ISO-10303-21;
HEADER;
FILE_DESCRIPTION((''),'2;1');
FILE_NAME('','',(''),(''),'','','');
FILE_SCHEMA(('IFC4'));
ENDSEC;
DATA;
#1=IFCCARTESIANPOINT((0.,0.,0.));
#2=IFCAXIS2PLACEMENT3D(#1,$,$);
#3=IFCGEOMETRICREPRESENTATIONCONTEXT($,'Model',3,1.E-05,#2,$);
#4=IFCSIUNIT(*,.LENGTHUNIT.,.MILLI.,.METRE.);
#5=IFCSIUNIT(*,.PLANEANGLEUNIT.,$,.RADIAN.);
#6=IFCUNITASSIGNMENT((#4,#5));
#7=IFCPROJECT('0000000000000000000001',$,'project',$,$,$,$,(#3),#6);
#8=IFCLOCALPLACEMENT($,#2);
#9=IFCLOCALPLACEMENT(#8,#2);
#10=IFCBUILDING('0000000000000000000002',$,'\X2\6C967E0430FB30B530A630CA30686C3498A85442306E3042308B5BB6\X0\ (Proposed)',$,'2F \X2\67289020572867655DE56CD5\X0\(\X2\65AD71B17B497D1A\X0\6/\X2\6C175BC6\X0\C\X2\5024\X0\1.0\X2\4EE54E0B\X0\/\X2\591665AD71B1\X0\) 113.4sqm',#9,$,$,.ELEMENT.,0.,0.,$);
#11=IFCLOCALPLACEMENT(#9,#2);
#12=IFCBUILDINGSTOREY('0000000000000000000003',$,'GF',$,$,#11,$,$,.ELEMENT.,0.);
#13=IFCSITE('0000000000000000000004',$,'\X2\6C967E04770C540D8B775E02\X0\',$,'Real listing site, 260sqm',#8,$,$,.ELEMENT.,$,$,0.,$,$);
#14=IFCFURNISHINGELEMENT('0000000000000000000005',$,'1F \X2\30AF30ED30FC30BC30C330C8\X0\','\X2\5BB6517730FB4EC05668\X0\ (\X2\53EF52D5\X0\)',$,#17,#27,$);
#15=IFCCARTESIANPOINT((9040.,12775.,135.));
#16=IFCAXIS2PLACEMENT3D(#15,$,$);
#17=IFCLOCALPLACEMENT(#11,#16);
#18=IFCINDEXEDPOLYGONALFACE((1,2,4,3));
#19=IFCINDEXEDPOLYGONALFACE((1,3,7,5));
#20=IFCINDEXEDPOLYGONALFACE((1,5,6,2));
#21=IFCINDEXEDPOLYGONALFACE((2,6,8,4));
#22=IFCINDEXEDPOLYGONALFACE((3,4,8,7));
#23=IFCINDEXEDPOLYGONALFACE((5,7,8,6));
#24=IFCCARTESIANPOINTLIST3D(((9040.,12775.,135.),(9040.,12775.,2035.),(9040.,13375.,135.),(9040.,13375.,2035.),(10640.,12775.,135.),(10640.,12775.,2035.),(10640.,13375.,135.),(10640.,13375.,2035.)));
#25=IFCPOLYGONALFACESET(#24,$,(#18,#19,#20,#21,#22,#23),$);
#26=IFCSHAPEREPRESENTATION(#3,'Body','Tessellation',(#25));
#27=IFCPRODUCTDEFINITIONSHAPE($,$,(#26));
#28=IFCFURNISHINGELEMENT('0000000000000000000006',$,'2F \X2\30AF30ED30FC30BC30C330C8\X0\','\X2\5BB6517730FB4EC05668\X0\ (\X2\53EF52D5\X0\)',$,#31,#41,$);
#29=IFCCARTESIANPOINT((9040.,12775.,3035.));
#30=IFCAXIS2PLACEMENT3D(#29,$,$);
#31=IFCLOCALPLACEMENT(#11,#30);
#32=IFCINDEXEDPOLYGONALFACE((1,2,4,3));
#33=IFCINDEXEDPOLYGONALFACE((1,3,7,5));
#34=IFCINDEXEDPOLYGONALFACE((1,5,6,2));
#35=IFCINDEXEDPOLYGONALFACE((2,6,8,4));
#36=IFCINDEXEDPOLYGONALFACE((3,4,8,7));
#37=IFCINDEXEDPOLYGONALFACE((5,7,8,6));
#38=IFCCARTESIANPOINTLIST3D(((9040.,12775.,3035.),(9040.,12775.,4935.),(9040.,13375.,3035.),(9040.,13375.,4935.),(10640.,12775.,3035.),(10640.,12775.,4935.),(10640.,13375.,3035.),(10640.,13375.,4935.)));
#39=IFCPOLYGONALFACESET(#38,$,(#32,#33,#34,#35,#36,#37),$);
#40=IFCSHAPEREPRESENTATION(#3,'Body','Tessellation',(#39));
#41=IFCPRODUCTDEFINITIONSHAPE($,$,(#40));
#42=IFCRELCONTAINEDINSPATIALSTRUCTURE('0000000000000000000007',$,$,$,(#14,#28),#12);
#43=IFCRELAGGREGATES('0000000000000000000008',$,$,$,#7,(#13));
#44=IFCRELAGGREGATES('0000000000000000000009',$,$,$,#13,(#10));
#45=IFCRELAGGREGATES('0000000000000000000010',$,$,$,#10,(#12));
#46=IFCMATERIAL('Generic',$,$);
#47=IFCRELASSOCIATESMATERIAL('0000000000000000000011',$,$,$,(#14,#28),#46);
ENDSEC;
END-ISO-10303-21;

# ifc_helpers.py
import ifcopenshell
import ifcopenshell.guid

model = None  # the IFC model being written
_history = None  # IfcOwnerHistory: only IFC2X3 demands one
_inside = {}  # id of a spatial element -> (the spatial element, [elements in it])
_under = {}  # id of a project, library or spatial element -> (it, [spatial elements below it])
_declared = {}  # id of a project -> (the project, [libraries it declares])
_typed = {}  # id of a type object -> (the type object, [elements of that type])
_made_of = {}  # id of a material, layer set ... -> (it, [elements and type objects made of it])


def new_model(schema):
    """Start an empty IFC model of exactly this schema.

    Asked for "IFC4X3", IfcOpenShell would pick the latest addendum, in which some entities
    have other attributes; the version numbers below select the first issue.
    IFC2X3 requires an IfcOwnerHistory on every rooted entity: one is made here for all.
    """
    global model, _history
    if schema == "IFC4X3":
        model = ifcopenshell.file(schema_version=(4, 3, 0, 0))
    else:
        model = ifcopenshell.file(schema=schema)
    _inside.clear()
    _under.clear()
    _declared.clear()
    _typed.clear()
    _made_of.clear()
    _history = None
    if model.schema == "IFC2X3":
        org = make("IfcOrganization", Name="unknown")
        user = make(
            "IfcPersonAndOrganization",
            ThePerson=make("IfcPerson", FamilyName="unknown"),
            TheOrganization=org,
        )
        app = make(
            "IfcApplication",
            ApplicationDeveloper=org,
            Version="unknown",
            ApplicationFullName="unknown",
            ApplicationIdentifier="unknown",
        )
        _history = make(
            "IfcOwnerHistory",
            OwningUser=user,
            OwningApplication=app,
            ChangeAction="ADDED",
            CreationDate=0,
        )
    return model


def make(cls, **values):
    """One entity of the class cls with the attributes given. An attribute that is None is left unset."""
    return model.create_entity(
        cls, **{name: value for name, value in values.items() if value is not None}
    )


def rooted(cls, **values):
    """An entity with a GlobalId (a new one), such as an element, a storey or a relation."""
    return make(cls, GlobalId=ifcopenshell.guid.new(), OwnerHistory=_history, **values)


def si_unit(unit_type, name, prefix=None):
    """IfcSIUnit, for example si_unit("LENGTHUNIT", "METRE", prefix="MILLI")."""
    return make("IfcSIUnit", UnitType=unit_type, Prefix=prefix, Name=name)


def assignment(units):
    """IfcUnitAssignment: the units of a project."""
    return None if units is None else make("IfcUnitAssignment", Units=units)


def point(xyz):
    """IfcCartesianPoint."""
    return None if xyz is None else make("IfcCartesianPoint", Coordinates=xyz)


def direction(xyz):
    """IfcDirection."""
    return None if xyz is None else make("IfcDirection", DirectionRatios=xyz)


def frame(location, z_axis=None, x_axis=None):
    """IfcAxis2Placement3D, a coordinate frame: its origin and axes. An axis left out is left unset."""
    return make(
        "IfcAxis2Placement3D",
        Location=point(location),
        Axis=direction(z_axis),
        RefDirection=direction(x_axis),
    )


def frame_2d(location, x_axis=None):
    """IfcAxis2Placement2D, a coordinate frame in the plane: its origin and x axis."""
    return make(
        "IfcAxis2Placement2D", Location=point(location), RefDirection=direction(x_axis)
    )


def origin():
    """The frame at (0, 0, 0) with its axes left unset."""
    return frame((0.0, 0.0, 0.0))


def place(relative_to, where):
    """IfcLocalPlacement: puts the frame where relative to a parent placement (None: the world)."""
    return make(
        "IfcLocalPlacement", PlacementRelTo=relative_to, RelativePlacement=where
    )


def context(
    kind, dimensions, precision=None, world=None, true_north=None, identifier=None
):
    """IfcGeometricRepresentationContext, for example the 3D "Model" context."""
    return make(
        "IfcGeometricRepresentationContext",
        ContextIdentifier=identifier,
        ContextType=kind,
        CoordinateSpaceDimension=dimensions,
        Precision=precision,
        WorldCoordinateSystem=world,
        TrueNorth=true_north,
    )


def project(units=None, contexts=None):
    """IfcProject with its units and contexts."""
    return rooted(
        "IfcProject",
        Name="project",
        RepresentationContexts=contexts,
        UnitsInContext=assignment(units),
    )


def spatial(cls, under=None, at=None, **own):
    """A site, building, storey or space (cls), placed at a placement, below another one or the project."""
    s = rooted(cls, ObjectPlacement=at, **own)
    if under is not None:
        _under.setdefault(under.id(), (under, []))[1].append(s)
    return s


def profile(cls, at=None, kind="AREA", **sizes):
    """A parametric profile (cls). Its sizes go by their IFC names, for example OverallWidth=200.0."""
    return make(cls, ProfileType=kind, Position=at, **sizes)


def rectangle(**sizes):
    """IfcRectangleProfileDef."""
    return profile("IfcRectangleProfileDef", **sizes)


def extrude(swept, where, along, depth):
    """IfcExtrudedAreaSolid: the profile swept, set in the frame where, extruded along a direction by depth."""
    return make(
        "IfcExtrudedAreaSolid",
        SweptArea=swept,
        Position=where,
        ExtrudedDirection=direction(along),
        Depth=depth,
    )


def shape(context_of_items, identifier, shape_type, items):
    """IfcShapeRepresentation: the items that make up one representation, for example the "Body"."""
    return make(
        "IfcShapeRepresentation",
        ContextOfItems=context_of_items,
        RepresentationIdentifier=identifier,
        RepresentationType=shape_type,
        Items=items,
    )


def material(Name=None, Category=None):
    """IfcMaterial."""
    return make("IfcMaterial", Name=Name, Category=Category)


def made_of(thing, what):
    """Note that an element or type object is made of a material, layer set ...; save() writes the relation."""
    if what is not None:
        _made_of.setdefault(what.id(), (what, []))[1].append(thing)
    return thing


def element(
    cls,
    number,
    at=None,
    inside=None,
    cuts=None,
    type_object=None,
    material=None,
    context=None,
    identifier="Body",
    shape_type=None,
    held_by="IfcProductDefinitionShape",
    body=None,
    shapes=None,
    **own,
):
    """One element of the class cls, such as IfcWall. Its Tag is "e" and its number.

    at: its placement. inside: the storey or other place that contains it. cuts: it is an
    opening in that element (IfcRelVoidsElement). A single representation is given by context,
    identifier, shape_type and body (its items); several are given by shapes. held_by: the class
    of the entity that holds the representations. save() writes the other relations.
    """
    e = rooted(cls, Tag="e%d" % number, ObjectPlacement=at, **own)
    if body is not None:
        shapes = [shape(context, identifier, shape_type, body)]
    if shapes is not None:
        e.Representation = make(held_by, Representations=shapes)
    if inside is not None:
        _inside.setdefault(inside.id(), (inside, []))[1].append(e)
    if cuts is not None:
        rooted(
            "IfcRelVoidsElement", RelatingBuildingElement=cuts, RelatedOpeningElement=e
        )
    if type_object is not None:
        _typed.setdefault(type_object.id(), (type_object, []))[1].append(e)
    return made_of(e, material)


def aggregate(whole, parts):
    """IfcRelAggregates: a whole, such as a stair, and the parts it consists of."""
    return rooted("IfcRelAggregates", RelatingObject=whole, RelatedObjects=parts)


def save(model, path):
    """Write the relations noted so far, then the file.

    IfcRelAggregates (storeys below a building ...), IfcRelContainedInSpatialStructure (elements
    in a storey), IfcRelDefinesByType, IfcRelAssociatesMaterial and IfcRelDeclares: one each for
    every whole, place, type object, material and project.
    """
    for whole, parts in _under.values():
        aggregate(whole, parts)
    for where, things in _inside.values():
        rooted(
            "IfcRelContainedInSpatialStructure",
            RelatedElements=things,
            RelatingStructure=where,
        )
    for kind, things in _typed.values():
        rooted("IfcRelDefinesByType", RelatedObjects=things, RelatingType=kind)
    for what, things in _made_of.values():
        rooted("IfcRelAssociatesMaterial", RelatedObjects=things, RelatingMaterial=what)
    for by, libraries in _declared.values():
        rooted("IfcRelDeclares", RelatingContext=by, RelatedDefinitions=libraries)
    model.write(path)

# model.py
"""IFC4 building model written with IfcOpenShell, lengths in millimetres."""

from ifc_helpers import new_model, si_unit, frame, frame_2d, origin, place, context, project, spatial, rectangle, extrude, material, element, save


model = new_model("IFC4")

# Units and contexts
model_context = context("Model", 3, precision=1e-05, world=origin())
ifc_project = project(units=[si_unit("LENGTHUNIT", "METRE", prefix="MILLI"), si_unit("PLANEANGLEUNIT", "RADIAN")], contexts=[model_context])

# Site, building, storey
site_placement = place(None, origin())
site = spatial("IfcSite", under=ifc_project, at=site_placement, Name="沖縄県名護市", ObjectType="Real listing site, 260sqm", CompositionType="ELEMENT", RefElevation=0.0)
building_placement = place(site_placement, origin())
building = spatial("IfcBuilding", under=site, at=building_placement, Name="沖縄・サウナと水風呂のある家 (Proposed)", ObjectType="2F 木造在来工法(断熱等級6/気密C値1.0以下/外断熱) 113.4sqm", CompositionType="ELEMENT", ElevationOfRefHeight=0.0, ElevationOfTerrain=0.0)
storey_placement = place(building_placement, origin())
storey = spatial("IfcBuildingStorey", under=building, at=storey_placement, Name="GF", CompositionType="ELEMENT", Elevation=0.0)

# Shared definitions
ifc_material_1 = material(Name="Generic")

# Furnishing elements
furnishing_1_placement = place(storey_placement, frame((9040.0, 12775.0, 135.0)))
element("IfcFurnishingElement", 1, at=furnishing_1_placement, inside=storey, material=ifc_material_1, Name="1F クローゼット", Description="家具・什器 (可動)", context=model_context, shape_type="SweptSolid", body=[
    extrude(rectangle(XDim=1600.0, YDim=600.0, at=frame_2d((800.0, 300.0))), frame((9040.0, 12775.0, 135.0)), (0.0, 0.0, 1.0), 1900.0),
])
furnishing_2_placement = place(storey_placement, frame((9040.0, 12775.0, 3035.0)))
element("IfcFurnishingElement", 2, at=furnishing_2_placement, inside=storey, material=ifc_material_1, Name="2F クローゼット", Description="家具・什器 (可動)", context=model_context, shape_type="SweptSolid", body=[
    extrude(rectangle(XDim=1600.0, YDim=600.0, at=frame_2d((800.0, 300.0))), frame((9040.0, 12775.0, 3035.0)), (0.0, 0.0, 1.0), 1900.0),
])

save(model, "model.ifc")
